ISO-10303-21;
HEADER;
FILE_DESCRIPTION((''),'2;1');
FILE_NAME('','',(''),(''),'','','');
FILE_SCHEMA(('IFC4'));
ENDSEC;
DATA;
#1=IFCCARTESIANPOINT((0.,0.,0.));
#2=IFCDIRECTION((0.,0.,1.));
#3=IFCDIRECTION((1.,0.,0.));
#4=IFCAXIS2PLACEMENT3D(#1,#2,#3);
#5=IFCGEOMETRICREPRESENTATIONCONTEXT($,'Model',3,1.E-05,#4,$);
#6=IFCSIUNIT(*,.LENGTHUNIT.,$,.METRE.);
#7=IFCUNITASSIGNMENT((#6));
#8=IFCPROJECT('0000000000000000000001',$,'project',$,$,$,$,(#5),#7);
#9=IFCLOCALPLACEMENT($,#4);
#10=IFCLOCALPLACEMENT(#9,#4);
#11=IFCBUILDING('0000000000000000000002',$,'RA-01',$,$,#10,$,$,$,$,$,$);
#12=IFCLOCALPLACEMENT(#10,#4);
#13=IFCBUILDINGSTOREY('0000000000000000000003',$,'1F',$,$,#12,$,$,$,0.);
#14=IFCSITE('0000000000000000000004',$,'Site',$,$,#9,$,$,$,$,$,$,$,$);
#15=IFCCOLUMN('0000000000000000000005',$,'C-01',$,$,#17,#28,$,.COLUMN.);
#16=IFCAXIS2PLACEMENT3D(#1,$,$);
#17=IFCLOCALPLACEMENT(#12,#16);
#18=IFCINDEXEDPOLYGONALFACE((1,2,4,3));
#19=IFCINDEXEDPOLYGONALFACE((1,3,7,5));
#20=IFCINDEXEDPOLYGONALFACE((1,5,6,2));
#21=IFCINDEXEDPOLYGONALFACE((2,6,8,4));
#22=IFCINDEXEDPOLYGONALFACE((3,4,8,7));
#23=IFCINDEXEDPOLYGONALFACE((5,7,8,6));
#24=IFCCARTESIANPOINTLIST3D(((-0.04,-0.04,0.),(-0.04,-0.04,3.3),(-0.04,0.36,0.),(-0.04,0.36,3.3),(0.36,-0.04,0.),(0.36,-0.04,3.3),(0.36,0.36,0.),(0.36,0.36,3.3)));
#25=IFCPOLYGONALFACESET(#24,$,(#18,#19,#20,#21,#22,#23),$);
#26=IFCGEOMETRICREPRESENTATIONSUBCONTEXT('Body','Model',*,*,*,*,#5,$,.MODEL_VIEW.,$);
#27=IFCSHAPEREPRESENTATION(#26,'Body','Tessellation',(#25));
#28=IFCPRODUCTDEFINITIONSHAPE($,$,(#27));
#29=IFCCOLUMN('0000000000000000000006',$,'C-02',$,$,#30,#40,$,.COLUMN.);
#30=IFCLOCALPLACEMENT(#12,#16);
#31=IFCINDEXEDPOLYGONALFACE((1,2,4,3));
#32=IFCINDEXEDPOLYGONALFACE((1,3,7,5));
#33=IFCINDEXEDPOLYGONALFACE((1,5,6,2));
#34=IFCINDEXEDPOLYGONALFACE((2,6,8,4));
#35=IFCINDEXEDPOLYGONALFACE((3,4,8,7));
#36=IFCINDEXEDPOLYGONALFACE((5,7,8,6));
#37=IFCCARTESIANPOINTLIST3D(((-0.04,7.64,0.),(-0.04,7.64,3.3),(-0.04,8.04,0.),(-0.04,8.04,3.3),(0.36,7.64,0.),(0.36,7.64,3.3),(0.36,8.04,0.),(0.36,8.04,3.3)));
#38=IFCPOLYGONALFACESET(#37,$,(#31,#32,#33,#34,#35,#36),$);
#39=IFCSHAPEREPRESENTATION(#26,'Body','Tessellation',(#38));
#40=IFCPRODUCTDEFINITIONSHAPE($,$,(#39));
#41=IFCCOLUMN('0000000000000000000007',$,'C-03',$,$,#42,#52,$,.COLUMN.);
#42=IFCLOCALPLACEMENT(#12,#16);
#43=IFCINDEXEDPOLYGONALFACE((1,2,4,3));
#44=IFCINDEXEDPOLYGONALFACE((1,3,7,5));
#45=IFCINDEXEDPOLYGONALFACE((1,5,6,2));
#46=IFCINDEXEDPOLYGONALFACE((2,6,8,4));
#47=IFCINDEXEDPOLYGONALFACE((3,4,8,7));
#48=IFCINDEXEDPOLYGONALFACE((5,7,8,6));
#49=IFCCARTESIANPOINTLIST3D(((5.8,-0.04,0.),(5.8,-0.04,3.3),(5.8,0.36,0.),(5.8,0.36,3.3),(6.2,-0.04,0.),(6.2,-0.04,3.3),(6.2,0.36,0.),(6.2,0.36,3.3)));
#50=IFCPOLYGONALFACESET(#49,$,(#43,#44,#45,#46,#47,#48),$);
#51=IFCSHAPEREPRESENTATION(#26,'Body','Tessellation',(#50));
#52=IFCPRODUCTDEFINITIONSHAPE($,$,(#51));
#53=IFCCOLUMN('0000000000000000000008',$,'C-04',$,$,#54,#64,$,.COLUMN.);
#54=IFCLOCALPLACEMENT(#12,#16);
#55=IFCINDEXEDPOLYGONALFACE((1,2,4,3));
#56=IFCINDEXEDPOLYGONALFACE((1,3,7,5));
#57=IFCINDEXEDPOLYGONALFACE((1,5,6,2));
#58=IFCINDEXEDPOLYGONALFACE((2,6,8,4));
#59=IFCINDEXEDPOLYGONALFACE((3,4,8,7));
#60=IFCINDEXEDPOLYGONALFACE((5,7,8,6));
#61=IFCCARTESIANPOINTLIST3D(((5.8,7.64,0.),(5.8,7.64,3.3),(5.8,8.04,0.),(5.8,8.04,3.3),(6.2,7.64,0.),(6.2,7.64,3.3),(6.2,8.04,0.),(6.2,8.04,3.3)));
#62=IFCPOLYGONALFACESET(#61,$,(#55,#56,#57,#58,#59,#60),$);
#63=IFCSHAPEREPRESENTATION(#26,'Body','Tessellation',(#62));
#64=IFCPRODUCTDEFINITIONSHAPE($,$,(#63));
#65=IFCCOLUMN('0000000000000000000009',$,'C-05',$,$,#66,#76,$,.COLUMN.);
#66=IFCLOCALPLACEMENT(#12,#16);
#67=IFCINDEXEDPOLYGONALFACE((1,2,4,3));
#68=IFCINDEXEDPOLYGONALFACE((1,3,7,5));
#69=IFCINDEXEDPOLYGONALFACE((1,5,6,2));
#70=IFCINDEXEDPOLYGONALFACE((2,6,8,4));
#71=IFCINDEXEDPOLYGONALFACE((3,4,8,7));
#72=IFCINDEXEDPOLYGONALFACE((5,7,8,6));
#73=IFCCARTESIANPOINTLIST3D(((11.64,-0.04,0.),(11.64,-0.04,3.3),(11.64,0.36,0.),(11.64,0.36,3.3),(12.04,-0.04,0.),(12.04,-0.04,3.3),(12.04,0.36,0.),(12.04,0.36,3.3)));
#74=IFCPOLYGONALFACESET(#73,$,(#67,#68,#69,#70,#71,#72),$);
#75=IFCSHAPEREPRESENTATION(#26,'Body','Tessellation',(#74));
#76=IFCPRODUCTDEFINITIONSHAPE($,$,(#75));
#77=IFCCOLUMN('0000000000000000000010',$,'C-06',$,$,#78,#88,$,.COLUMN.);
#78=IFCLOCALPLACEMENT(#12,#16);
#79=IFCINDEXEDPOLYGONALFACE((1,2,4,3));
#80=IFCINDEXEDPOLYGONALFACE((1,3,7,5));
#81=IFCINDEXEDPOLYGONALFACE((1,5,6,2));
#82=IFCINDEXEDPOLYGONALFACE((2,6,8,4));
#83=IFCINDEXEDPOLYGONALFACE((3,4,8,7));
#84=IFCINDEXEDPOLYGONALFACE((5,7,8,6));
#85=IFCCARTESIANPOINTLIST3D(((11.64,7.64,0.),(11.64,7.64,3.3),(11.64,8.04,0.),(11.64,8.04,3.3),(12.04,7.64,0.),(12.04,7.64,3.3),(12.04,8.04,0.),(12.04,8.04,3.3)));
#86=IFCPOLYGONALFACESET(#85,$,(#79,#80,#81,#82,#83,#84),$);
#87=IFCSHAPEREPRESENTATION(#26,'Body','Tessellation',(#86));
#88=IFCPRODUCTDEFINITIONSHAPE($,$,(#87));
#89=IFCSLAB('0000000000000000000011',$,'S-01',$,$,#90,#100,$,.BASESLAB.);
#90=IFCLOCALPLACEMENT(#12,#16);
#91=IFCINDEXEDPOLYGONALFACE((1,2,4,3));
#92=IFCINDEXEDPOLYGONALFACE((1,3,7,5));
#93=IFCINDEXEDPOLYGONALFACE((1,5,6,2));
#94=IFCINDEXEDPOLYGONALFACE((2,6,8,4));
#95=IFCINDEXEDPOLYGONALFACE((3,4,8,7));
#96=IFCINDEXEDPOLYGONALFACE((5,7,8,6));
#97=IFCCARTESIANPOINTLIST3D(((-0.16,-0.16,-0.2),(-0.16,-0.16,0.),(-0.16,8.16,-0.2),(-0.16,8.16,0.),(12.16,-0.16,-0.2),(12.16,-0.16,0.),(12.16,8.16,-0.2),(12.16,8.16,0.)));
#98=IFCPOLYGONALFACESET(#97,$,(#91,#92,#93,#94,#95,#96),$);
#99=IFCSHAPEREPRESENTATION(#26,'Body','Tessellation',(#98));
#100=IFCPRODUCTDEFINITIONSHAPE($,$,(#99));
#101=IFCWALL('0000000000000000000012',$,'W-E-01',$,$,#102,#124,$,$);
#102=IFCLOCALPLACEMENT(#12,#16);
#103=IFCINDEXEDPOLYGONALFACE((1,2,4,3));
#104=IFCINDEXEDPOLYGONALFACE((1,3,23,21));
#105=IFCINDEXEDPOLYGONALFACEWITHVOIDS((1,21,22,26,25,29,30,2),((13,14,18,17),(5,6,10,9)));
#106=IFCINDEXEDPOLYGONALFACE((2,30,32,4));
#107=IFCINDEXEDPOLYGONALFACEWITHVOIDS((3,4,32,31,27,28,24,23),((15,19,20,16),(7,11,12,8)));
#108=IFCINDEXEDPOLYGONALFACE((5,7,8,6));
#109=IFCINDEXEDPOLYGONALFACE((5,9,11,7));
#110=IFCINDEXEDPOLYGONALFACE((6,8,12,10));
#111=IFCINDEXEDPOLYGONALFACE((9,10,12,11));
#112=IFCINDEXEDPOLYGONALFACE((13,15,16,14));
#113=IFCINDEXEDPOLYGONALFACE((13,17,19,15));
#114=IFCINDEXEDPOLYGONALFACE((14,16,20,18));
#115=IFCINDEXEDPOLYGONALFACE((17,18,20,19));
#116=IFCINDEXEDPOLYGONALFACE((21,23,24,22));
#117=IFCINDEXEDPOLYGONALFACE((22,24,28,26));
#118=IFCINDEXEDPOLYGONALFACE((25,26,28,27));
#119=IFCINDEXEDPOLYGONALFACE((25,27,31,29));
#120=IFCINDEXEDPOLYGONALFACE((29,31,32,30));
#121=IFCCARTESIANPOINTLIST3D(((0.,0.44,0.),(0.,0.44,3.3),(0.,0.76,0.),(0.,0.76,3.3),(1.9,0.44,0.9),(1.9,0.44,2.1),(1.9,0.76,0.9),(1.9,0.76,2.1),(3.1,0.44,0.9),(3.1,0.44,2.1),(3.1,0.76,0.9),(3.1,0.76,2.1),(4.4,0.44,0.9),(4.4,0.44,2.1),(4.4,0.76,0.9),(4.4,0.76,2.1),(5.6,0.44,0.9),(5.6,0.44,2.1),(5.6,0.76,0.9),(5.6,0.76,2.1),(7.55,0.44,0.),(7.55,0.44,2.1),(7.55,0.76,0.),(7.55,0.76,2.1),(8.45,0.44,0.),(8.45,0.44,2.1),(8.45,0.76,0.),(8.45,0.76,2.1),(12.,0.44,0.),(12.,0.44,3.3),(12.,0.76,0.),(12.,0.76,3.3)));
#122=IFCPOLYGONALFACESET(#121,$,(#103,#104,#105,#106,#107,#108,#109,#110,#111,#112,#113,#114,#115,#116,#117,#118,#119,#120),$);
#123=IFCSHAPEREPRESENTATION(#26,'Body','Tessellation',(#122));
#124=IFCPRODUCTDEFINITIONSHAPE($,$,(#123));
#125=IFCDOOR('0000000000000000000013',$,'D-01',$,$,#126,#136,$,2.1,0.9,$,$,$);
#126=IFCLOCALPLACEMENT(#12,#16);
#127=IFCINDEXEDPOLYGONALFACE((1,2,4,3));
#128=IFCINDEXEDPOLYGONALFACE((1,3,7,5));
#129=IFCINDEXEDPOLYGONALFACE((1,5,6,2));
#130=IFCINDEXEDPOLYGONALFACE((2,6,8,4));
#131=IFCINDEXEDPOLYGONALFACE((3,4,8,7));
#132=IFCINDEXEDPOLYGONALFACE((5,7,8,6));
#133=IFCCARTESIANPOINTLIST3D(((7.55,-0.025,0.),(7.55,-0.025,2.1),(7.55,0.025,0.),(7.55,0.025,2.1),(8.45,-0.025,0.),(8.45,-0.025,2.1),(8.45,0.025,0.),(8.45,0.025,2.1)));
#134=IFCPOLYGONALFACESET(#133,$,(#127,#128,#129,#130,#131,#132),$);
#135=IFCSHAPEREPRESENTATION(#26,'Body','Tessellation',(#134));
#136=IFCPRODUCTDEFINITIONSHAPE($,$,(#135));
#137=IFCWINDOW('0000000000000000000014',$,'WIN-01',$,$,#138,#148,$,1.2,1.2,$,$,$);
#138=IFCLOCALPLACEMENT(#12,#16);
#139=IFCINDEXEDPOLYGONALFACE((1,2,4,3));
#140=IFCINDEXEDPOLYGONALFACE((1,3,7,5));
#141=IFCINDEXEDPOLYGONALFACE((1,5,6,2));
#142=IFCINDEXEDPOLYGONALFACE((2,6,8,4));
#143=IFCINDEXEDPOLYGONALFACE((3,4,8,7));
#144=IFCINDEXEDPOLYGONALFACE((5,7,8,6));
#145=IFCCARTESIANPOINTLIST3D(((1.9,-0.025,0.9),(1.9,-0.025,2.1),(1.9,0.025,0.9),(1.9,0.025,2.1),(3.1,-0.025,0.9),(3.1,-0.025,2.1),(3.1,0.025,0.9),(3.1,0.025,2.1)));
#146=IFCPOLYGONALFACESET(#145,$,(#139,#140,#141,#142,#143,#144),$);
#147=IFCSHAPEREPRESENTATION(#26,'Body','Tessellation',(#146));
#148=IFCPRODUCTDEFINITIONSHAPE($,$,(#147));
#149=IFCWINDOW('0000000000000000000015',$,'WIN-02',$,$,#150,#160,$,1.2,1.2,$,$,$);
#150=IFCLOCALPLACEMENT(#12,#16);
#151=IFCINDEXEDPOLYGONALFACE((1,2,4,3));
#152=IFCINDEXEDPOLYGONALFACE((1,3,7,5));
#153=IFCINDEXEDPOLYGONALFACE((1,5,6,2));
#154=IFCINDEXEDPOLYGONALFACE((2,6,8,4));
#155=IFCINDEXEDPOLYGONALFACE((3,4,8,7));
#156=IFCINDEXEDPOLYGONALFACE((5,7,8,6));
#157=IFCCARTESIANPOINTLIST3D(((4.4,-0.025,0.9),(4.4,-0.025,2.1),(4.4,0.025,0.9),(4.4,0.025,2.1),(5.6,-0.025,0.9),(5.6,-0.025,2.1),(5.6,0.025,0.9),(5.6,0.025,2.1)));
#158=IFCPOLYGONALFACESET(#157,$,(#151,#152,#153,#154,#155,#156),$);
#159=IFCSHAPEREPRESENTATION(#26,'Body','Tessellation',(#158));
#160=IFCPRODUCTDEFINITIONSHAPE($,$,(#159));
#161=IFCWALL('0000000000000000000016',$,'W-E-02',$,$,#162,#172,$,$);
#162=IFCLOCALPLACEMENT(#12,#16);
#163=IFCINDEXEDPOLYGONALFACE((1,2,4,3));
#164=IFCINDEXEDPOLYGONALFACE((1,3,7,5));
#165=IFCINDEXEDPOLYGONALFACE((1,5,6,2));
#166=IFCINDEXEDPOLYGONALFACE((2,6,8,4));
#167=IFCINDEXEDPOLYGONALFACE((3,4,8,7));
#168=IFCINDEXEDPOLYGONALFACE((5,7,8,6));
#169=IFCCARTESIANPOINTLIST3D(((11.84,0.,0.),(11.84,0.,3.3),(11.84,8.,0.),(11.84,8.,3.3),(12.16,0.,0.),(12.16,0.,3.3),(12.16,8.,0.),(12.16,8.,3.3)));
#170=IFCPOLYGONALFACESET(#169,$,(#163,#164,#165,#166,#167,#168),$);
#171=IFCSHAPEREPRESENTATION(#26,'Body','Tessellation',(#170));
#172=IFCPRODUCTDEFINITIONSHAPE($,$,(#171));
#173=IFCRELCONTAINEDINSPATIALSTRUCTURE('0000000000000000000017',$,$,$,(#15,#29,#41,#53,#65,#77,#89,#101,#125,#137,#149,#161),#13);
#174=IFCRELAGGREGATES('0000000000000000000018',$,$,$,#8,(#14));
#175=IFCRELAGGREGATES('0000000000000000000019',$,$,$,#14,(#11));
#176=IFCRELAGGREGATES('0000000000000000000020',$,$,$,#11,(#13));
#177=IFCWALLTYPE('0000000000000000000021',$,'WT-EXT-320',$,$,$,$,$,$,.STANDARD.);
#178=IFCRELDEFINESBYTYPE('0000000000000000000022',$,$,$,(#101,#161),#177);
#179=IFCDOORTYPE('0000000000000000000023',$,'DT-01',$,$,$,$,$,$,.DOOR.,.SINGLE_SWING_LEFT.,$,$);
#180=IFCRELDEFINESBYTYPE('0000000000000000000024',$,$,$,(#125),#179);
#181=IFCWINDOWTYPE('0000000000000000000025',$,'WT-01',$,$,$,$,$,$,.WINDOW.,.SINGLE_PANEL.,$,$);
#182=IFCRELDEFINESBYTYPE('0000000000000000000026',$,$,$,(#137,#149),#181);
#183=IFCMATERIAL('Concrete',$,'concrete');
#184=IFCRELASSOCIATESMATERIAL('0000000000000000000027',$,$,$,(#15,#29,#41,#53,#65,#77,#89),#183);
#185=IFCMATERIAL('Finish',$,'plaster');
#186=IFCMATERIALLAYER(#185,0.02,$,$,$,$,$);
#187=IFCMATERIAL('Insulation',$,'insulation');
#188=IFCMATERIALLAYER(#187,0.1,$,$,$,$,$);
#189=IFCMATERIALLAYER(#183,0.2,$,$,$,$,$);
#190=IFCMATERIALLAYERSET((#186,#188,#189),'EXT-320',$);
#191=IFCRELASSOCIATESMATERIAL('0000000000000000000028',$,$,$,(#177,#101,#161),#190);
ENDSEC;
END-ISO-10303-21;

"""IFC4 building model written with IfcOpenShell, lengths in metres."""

from ifc_helpers import new_model, si_unit, frame, frame_2d, origin_with_axes, origin_2d_with_axis, place, context, subcontext, project, spatial, polyline, rectangle, outline, extrude, material, layer, layer_set, layer_usage, type_object, element, fill, save


model = new_model("IFC4")

# Units and contexts
model_context = context("Model", 3, precision=1e-05, world=origin_with_axes())
body_context = subcontext(model_context, "Body", "Model", "MODEL_VIEW")
ifc_project = project(units=[si_unit("LENGTHUNIT", "METRE")], contexts=[model_context])

# Site, building, storey
site_placement = place(None, origin_with_axes())
site = spatial("IfcSite", under=ifc_project, at=site_placement, Name="Site")
building_placement = place(site_placement, origin_with_axes())
building = spatial("IfcBuilding", under=site, at=building_placement, Name="RA-01")
storey_placement = place(building_placement, origin_with_axes())
storey = spatial("IfcBuildingStorey", under=building, at=storey_placement, Name="1F", Elevation=0.0)

# Columns
ifc_material_1 = material(Name="Concrete", Category="concrete")
for number, where, z_axis, x_axis, name in (
    (1, (0.16, 0.16, 0.0), (0.0, 0.0, 1.0), (1.0, 0.0, 0.0), "C-01"),
    (2, (0.16, 7.84, 0.0), (0.0, 0.0, 1.0), (1.0, 0.0, 0.0), "C-02"),
    (3, (6.0, 0.16, 0.0), (0.0, 0.0, 1.0), (1.0, 0.0, 0.0), "C-03"),
    (4, (6.0, 7.84, 0.0), (0.0, 0.0, 1.0), (1.0, 0.0, 0.0), "C-04"),
    (5, (11.84, 0.16, 0.0), (0.0, 0.0, 1.0), (1.0, 0.0, 0.0), "C-05"),
    (6, (11.84, 7.84, 0.0), (0.0, 0.0, 1.0), (1.0, 0.0, 0.0), "C-06"),
):
    element("IfcColumn", number, at=place(storey_placement, frame(where, z_axis=z_axis, x_axis=x_axis)), inside=storey, material=ifc_material_1, Name=name, PredefinedType="COLUMN", context=body_context, shape_type="SweptSolid", body=[
        extrude(rectangle(XDim=0.4, YDim=0.4, at=origin_2d_with_axis()), origin_with_axes(), (0.0, 0.0, 1.0), 3.3),
    ])

# Slab
slab_placement = place(storey_placement, frame((0.0, 0.0, -0.2), z_axis=(0.0, 0.0, 1.0), x_axis=(1.0, 0.0, 0.0)))
element("IfcSlab", 7, at=slab_placement, inside=storey, material=ifc_material_1, Name="S-01", PredefinedType="BASESLAB", context=body_context, shape_type="SweptSolid", body=[
    extrude(outline(polyline([(-0.16, -0.16), (12.16, -0.16), (12.16, 8.16), (-0.16, 8.16), (-0.16, -0.16)])), origin_with_axes(), (0.0, 0.0, 1.0), 0.2),
])

# Wall, openings, door, windows
ifc_material_2 = material(Name="Finish", Category="plaster")
ifc_layer_1 = layer(ifc_material_2, 0.02)
ifc_material_3 = material(Name="Insulation", Category="insulation")
ifc_layer_2 = layer(ifc_material_3, 0.1)
ifc_layer_3 = layer(ifc_material_1, 0.2)
ifc_layer_set_1 = layer_set([ifc_layer_1, ifc_layer_2, ifc_layer_3], Name="EXT-320")
ifc_layer_usage_1 = layer_usage(ifc_layer_set_1, "AXIS2", "POSITIVE", -0.16)
wall_type_1 = type_object("IfcWallType", Name="WT-EXT-320", PredefinedType="STANDARD", material=ifc_layer_set_1)
wall_1_placement = place(storey_placement, frame((0.0, 0.6, 0.0), z_axis=(0.0, 0.0, 1.0), x_axis=(1.0, 0.0, 0.0)))
wall_1 = element("IfcWall", 8, at=wall_1_placement, inside=storey, type_object=wall_type_1, material=ifc_layer_usage_1, Name="W-E-01", context=body_context, shape_type="SweptSolid", body=[
    extrude(rectangle(XDim=12.0, YDim=0.32, at=frame_2d((6.0, 0.0), x_axis=(1.0, 0.0))), origin_with_axes(), (0.0, 0.0, 1.0), 3.3),
])
opening_1_placement = place(wall_1_placement, frame((8.0, 0.0, 0.0), z_axis=(0.0, 0.0, 1.0), x_axis=(1.0, 0.0, 0.0)))
opening_1 = element("IfcOpeningElement", 9, at=opening_1_placement, cuts=wall_1, PredefinedType="OPENING", context=body_context, shape_type="SweptSolid", body=[
    extrude(rectangle(XDim=0.9, YDim=0.42, at=origin_2d_with_axis()), origin_with_axes(), (0.0, 0.0, 1.0), 2.1),
])
opening_2_placement = place(wall_1_placement, frame((2.5, 0.0, 0.9), z_axis=(0.0, 0.0, 1.0), x_axis=(1.0, 0.0, 0.0)))
opening_2 = element("IfcOpeningElement", 10, at=opening_2_placement, cuts=wall_1, PredefinedType="OPENING", context=body_context, shape_type="SweptSolid", body=[
    extrude(rectangle(XDim=1.2, YDim=0.42, at=origin_2d_with_axis()), origin_with_axes(), (0.0, 0.0, 1.0), 1.2),
])
opening_3_placement = place(wall_1_placement, frame((5.0, 0.0, 0.9), z_axis=(0.0, 0.0, 1.0), x_axis=(1.0, 0.0, 0.0)))
opening_3 = element("IfcOpeningElement", 11, at=opening_3_placement, cuts=wall_1, PredefinedType="OPENING", context=body_context, shape_type="SweptSolid", body=[
    extrude(rectangle(XDim=1.2, YDim=0.42, at=origin_2d_with_axis()), origin_with_axes(), (0.0, 0.0, 1.0), 1.2),
])
door_type_1 = type_object("IfcDoorType", Name="DT-01", OperationType="SINGLE_SWING_LEFT", PredefinedType="DOOR")
door_1_placement = place(opening_1_placement, frame((0.0, -0.6, 0.0), z_axis=(0.0, 0.0, 1.0), x_axis=(1.0, 0.0, 0.0)))
door_1 = element("IfcDoor", 12, at=door_1_placement, inside=storey, type_object=door_type_1, Name="D-01", OverallHeight=2.1, OverallWidth=0.9, context=body_context, shape_type="SweptSolid", body=[
    extrude(rectangle(XDim=0.9, YDim=0.05, at=origin_2d_with_axis()), origin_with_axes(), (0.0, 0.0, 1.0), 2.1),
])
fill(opening_1, door_1)
window_type_1 = type_object("IfcWindowType", Name="WT-01", PartitioningType="SINGLE_PANEL", PredefinedType="WINDOW")
window_1_placement = place(opening_2_placement, frame((0.0, -0.6, 0.0), z_axis=(0.0, 0.0, 1.0), x_axis=(1.0, 0.0, 0.0)))
window_1 = element("IfcWindow", 13, at=window_1_placement, inside=storey, type_object=window_type_1, Name="WIN-01", OverallHeight=1.2, OverallWidth=1.2, context=body_context, shape_type="SweptSolid", body=[
    extrude(rectangle(XDim=1.2, YDim=0.05, at=origin_2d_with_axis()), origin_with_axes(), (0.0, 0.0, 1.0), 1.2),
])
fill(opening_2, window_1)
window_2_placement = place(opening_3_placement, frame((0.0, -0.6, 0.0), z_axis=(0.0, 0.0, 1.0), x_axis=(1.0, 0.0, 0.0)))
window_2 = element("IfcWindow", 14, at=window_2_placement, inside=storey, type_object=window_type_1, Name="WIN-02", OverallHeight=1.2, OverallWidth=1.2, context=body_context, shape_type="SweptSolid", body=[
    extrude(rectangle(XDim=1.2, YDim=0.05, at=origin_2d_with_axis()), origin_with_axes(), (0.0, 0.0, 1.0), 1.2),
])
fill(opening_3, window_2)

# Wall
ifc_layer_usage_2 = layer_usage(ifc_layer_set_1, "AXIS2", "POSITIVE", -0.16)
wall_2_placement = place(storey_placement, frame((12.0, 0.0, 0.0), z_axis=(0.0, 0.0, 1.0), x_axis=(0.0, 1.0, 0.0)))
element("IfcWall", 15, at=wall_2_placement, inside=storey, type_object=wall_type_1, material=ifc_layer_usage_2, Name="W-E-02", context=body_context, shape_type="SweptSolid", body=[
    extrude(rectangle(XDim=8.0, YDim=0.32, at=frame_2d((4.0, 0.0), x_axis=(1.0, 0.0))), origin_with_axes(), (0.0, 0.0, 1.0), 3.3),
])

save(model, "model.ifc")
